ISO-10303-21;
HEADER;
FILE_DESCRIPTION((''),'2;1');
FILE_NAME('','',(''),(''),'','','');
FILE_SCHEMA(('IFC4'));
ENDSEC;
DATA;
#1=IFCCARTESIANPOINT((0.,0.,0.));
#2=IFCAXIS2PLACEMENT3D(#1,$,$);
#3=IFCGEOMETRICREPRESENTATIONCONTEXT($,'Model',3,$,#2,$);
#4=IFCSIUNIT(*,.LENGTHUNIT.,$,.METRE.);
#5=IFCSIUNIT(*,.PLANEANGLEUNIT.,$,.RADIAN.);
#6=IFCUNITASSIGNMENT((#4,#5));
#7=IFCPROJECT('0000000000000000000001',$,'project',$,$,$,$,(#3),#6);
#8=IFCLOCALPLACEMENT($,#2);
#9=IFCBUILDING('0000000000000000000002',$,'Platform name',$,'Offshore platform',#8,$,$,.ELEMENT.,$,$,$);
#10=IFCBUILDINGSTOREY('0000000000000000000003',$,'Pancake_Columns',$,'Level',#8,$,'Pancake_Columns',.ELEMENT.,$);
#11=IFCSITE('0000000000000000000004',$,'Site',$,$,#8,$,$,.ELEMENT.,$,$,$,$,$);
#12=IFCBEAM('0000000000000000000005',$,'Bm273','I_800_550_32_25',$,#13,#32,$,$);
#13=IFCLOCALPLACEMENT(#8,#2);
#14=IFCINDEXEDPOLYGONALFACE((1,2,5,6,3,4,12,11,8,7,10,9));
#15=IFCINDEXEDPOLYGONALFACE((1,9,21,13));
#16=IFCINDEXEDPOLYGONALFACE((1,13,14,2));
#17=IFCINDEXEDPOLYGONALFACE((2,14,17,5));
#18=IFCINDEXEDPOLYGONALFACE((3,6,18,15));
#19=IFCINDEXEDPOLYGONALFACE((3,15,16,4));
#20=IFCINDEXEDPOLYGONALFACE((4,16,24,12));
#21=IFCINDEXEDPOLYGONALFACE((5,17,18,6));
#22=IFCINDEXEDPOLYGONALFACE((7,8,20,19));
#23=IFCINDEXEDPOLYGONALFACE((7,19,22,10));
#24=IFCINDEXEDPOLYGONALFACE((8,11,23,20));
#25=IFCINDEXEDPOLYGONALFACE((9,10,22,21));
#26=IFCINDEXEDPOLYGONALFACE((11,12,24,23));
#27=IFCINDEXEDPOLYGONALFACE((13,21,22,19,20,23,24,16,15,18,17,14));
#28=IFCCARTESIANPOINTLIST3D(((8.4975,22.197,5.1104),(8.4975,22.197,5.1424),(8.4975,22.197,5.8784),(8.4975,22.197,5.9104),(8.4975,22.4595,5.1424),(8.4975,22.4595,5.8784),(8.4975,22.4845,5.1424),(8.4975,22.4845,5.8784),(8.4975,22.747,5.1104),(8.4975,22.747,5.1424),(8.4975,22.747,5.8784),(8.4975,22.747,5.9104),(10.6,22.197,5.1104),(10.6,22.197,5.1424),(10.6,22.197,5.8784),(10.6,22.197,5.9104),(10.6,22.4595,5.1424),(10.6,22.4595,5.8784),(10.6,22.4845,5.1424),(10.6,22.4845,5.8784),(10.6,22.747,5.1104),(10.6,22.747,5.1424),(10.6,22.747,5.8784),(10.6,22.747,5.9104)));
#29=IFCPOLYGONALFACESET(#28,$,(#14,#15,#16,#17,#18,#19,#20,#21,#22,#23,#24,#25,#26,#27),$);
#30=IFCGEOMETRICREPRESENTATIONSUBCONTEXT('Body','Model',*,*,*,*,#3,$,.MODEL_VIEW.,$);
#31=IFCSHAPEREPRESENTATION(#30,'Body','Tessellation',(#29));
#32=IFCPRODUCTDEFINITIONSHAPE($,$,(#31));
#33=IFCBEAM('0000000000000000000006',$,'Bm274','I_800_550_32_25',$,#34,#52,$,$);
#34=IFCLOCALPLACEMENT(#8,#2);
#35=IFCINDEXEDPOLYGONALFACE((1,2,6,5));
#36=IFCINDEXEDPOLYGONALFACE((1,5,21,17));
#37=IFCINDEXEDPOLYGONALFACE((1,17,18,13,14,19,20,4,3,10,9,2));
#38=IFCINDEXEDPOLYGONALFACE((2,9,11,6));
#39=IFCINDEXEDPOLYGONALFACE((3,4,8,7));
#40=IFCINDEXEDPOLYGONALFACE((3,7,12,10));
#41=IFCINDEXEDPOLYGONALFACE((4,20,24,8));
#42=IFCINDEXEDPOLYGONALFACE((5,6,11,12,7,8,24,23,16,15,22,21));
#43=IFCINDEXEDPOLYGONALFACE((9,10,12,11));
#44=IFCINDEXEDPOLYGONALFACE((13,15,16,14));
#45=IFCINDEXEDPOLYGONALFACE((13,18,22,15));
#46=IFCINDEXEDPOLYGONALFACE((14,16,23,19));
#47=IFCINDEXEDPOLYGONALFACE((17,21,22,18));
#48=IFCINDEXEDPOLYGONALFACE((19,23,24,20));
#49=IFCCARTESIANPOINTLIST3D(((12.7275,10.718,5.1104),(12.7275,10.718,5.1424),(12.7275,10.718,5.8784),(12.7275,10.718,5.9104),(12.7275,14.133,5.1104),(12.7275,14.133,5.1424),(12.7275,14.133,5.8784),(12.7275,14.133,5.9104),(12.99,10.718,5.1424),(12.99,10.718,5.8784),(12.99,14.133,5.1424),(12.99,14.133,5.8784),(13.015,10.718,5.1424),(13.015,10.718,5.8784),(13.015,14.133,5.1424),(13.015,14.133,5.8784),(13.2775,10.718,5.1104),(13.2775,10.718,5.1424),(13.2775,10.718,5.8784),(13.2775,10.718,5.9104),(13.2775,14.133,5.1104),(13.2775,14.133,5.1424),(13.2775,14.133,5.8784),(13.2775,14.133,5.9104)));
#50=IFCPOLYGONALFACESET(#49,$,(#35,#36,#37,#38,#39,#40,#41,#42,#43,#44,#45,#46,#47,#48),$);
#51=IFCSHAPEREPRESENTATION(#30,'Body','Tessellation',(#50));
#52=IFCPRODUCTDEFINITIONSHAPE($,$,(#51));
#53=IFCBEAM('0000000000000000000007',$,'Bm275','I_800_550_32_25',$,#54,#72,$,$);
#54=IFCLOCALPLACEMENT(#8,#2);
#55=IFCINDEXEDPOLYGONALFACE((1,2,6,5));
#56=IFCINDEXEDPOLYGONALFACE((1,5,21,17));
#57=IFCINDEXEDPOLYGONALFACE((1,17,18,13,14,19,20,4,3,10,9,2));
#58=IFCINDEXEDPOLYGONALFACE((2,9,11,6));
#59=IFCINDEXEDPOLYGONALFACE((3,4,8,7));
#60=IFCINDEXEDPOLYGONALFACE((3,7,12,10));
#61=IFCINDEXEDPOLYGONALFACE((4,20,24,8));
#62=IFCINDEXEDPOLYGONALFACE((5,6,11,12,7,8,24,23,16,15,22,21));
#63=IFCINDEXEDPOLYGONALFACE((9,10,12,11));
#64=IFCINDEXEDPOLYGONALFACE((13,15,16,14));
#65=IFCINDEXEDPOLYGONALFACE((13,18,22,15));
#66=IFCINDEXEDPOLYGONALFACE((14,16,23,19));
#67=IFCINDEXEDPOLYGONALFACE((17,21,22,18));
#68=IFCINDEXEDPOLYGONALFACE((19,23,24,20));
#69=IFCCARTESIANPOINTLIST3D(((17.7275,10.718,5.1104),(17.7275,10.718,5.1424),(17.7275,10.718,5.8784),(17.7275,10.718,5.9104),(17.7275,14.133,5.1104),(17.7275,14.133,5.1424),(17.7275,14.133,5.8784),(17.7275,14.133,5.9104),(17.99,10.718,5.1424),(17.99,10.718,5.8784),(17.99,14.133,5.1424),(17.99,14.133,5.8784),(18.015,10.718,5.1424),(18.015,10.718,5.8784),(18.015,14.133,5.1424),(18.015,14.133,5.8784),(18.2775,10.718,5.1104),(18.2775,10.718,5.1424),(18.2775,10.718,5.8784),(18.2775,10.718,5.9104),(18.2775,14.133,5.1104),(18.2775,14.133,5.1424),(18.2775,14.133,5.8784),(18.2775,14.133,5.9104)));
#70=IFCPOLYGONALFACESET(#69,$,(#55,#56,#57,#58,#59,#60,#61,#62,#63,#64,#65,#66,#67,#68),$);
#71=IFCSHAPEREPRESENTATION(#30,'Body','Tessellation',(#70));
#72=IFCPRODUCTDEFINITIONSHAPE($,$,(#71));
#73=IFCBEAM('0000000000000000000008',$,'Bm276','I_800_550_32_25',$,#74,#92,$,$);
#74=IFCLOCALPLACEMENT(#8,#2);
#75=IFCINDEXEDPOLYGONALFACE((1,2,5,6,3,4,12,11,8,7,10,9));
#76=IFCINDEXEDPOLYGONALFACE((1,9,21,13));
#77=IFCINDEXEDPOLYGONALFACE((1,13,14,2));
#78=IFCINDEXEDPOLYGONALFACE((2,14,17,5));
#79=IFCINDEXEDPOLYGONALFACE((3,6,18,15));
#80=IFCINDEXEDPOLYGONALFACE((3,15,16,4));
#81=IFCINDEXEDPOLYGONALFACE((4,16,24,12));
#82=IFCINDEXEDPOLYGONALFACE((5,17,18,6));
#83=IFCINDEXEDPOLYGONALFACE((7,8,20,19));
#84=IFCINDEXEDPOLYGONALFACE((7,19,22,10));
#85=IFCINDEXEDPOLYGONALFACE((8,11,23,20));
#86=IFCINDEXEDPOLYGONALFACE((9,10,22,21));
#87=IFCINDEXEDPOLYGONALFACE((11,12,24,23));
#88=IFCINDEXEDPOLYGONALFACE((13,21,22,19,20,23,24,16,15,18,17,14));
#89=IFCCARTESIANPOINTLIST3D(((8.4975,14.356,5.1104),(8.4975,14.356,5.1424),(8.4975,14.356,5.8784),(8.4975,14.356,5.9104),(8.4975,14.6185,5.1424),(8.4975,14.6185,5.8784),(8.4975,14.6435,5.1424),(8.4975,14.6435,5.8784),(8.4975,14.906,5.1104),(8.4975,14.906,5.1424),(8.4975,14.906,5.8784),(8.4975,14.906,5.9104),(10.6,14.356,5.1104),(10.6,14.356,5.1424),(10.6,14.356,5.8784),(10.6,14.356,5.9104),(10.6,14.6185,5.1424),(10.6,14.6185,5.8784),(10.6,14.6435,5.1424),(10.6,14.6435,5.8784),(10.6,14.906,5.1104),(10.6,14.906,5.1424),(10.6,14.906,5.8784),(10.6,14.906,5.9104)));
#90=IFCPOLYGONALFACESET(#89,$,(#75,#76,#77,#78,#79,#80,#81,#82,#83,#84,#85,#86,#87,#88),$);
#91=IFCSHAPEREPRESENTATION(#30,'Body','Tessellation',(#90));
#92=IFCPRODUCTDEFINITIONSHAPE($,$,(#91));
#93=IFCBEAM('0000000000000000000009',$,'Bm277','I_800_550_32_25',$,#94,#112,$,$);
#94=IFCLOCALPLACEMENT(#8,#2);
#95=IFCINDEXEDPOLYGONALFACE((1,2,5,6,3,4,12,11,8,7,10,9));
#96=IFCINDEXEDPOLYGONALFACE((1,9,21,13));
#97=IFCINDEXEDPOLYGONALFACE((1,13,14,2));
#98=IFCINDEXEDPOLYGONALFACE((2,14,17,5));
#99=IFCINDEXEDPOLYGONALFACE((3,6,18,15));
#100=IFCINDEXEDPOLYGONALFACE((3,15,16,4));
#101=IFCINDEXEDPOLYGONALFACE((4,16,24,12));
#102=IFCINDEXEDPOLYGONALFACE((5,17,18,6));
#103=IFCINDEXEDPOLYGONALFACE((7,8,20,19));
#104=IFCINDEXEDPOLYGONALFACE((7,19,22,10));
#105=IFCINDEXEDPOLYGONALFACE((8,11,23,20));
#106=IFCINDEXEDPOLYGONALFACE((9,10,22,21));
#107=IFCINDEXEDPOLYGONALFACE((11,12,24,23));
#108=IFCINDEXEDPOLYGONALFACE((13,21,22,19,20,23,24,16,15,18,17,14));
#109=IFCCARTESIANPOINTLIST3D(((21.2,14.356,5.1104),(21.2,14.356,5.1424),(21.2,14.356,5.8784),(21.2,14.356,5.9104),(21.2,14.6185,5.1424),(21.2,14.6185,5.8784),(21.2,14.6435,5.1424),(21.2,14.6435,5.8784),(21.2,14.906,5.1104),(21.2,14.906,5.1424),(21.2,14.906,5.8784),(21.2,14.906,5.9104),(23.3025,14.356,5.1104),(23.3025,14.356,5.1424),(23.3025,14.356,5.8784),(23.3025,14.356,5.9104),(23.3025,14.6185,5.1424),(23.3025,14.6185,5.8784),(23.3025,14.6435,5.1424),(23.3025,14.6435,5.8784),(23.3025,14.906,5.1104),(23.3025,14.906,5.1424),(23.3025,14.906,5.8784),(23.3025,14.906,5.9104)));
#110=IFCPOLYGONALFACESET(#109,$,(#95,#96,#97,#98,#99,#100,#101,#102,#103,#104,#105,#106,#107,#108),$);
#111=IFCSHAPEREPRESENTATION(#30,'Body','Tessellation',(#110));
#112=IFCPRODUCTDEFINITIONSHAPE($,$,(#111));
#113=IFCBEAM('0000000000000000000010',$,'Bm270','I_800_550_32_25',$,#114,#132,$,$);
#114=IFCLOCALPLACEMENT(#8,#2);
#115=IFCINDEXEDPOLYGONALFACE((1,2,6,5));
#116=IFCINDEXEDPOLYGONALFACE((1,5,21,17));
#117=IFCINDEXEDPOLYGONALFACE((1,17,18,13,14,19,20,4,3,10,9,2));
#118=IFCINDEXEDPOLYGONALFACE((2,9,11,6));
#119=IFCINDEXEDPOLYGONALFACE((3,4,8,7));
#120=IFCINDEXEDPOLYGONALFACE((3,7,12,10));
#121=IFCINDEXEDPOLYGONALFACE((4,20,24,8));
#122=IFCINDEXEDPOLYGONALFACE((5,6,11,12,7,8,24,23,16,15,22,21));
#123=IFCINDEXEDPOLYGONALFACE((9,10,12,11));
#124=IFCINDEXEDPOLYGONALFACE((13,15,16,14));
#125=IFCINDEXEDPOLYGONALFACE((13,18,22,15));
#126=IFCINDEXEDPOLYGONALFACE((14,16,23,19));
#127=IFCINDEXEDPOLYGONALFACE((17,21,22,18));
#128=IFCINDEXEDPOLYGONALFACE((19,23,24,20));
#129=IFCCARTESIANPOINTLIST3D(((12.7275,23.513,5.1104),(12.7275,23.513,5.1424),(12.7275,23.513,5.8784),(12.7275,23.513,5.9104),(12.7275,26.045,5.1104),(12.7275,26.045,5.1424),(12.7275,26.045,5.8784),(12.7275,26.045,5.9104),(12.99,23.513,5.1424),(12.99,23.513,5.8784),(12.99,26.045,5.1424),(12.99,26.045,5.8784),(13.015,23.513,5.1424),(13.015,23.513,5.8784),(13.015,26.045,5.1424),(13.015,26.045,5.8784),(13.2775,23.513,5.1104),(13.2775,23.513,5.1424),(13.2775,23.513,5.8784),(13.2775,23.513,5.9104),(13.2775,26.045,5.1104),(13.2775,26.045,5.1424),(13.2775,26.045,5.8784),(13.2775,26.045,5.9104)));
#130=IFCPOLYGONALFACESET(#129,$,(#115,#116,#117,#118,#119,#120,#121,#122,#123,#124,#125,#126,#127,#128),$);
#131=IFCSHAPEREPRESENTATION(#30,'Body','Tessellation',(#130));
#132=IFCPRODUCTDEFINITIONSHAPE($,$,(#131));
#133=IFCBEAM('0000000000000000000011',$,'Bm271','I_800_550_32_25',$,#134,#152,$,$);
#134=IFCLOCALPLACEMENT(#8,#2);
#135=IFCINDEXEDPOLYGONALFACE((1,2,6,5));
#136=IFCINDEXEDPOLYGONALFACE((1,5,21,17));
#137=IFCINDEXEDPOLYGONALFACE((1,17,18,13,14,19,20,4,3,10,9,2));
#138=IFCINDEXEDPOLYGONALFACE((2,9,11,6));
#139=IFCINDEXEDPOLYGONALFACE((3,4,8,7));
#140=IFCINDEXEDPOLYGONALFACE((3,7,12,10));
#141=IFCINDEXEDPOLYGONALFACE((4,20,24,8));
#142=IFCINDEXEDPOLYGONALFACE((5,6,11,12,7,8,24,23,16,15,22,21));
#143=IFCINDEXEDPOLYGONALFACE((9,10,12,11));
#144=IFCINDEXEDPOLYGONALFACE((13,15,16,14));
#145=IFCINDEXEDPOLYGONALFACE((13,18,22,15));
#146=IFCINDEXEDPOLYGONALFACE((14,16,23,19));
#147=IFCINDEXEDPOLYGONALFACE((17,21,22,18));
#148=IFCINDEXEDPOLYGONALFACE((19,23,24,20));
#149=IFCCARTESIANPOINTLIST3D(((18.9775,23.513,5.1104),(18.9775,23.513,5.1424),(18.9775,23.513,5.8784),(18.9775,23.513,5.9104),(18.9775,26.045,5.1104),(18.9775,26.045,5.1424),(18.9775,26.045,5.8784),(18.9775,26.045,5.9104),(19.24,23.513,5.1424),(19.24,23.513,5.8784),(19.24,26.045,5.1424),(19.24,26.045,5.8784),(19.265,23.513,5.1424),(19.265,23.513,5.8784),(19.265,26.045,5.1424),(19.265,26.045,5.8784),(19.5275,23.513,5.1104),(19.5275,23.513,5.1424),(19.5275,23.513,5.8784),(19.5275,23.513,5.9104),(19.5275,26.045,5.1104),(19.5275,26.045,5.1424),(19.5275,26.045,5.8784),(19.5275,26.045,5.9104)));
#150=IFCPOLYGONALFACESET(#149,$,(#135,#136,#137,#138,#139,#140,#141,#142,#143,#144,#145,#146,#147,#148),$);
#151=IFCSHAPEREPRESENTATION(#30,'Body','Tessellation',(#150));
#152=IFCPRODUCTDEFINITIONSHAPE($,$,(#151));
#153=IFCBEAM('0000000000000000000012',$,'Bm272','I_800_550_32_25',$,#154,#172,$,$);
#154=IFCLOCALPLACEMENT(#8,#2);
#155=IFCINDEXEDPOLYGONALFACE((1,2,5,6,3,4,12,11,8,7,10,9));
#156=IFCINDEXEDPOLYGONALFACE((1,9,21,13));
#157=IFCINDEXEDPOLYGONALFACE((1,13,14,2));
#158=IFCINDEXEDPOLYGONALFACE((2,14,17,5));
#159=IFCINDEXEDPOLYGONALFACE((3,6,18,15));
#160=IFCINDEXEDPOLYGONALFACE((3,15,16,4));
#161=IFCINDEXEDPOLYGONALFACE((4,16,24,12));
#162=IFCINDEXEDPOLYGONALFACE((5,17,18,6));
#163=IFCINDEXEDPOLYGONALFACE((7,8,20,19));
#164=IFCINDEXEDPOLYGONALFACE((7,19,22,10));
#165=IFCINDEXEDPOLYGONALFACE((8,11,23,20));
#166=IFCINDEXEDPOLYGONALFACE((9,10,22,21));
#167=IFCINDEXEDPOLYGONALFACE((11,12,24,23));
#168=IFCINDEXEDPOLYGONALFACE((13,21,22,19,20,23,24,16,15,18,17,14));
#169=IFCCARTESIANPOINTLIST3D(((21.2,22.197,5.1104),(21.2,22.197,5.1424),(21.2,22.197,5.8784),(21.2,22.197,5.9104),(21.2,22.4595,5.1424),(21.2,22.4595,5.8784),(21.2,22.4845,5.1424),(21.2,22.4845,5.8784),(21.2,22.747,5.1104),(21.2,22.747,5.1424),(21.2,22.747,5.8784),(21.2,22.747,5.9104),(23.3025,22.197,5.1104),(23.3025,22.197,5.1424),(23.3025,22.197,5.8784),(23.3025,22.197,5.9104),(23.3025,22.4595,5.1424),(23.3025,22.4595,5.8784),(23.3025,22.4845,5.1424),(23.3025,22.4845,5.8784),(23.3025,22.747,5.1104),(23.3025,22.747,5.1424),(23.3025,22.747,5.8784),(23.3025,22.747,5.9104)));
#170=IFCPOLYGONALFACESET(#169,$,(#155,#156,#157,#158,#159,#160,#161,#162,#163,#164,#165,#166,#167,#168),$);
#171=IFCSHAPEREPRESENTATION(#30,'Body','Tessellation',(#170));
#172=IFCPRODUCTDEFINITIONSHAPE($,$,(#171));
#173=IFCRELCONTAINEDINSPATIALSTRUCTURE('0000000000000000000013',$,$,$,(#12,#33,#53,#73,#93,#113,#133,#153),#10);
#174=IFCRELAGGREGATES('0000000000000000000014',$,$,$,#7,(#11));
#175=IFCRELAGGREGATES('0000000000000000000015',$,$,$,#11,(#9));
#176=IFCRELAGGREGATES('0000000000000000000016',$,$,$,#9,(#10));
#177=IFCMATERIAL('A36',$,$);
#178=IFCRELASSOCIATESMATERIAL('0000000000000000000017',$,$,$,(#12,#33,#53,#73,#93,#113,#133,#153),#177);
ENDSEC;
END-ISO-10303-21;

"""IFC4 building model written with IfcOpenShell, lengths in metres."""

from ifc_helpers import new_model, si_unit, frame, origin, origin_2d, place, context, subcontext, project, spatial, i_section, extrude, source, transform, mapped, material, element, save


model = new_model("IFC4")

# Units and contexts
model_context = context("Model", 3, world=origin())
body_context = subcontext(model_context, "Body", "Model", "MODEL_VIEW")
ifc_project = project(units=[si_unit("LENGTHUNIT", "METRE"), si_unit("PLANEANGLEUNIT", "RADIAN")], contexts=[model_context])

# Site, building, storey
placement_1 = place(None, origin())
site = spatial("IfcSite", under=ifc_project, at=placement_1, Name="Site", CompositionType="ELEMENT")
building = spatial("IfcBuilding", under=site, at=placement_1, Name="Platform name", ObjectType="Offshore platform", CompositionType="ELEMENT")
storey = spatial("IfcBuildingStorey", under=building, at=placement_1, Name="Pancake_Columns", ObjectType="Level", LongName="Pancake_Columns", CompositionType="ELEMENT")

# Beams
ifc_material = material(Name="A36")
shared_shape_1 = source(origin(), body_context, "Body", "SweptSolid", [
    extrude(i_section(OverallWidth=0.55, OverallDepth=0.8, WebThickness=0.025, FlangeThickness=0.032, FilletRadius=0.0, at=origin_2d()), frame((0.0, 0.0, 0.0), z_axis=(1.0, 0.0, 0.0), x_axis=(0.0, 1.0, 0.0)), (0.0, 0.0, 1.0), 2.1025),
])
placement_2 = place(None, origin())
placement_3 = place(placement_2, origin())
placement_4 = place(placement_3, origin())
beam_1_placement = place(placement_4, frame((8.4975, 22.472, 5.5104)))
element("IfcBeam", 1, at=beam_1_placement, inside=storey, material=ifc_material, Name="Bm273", Description="I_800_550_32_25", context=body_context, shape_type="MappedRepresentation", body=[
    mapped(shared_shape_1, transform((0.0, 0.0, 0.0), scale=1.0)),
])
shared_shape_2 = source(origin(), body_context, "Body", "SweptSolid", [
    extrude(i_section(OverallWidth=0.55, OverallDepth=0.8, WebThickness=0.025, FlangeThickness=0.032, FilletRadius=0.0, at=origin_2d()), frame((0.0, 0.0, 0.0), z_axis=(0.0, -1.0, 0.0), x_axis=(1.0, 0.0, 0.0)), (0.0, 0.0, 1.0), 3.415),
])
placement_5 = place(None, origin())
placement_6 = place(placement_5, origin())
placement_7 = place(placement_6, origin())
beam_2_placement = place(placement_7, frame((13.0025, 14.133, 5.5104)))
element("IfcBeam", 2, at=beam_2_placement, inside=storey, material=ifc_material, Name="Bm274", Description="I_800_550_32_25", context=body_context, shape_type="MappedRepresentation", body=[
    mapped(shared_shape_2, transform((0.0, 0.0, 0.0), scale=1.0)),
])
shared_shape_3 = source(origin(), body_context, "Body", "SweptSolid", [
    extrude(i_section(OverallWidth=0.55, OverallDepth=0.8, WebThickness=0.025, FlangeThickness=0.032, FilletRadius=0.0, at=origin_2d()), frame((0.0, 0.0, 0.0), z_axis=(0.0, -1.0, 0.0), x_axis=(1.0, 0.0, 0.0)), (0.0, 0.0, 1.0), 3.415),
])
placement_8 = place(None, origin())
placement_9 = place(placement_8, origin())
placement_10 = place(placement_9, origin())
beam_3_placement = place(placement_10, frame((18.0025, 14.133, 5.5104)))
element("IfcBeam", 3, at=beam_3_placement, inside=storey, material=ifc_material, Name="Bm275", Description="I_800_550_32_25", context=body_context, shape_type="MappedRepresentation", body=[
    mapped(shared_shape_3, transform((0.0, 0.0, 0.0), scale=1.0)),
])
shared_shape_4 = source(origin(), body_context, "Body", "SweptSolid", [
    extrude(i_section(OverallWidth=0.55, OverallDepth=0.8, WebThickness=0.025, FlangeThickness=0.032, FilletRadius=0.0, at=origin_2d()), frame((0.0, 0.0, 0.0), z_axis=(1.0, 0.0, 0.0), x_axis=(0.0, 1.0, 0.0)), (0.0, 0.0, 1.0), 2.1025),
])
placement_11 = place(None, origin())
placement_12 = place(placement_11, origin())
placement_13 = place(placement_12, origin())
beam_4_placement = place(placement_13, frame((8.4975, 14.631, 5.5104)))
element("IfcBeam", 4, at=beam_4_placement, inside=storey, material=ifc_material, Name="Bm276", Description="I_800_550_32_25", context=body_context, shape_type="MappedRepresentation", body=[
    mapped(shared_shape_4, transform((0.0, 0.0, 0.0), scale=1.0)),
])
shared_shape_5 = source(origin(), body_context, "Body", "SweptSolid", [
    extrude(i_section(OverallWidth=0.55, OverallDepth=0.8, WebThickness=0.025, FlangeThickness=0.032, FilletRadius=0.0, at=origin_2d()), frame((0.0, 0.0, 0.0), z_axis=(1.0, 0.0, 0.0), x_axis=(0.0, 1.0, 0.0)), (0.0, 0.0, 1.0), 2.1025),
])
placement_14 = place(None, origin())
placement_15 = place(placement_14, origin())
placement_16 = place(placement_15, origin())
beam_5_placement = place(placement_16, frame((21.2, 14.631, 5.5104)))
element("IfcBeam", 5, at=beam_5_placement, inside=storey, material=ifc_material, Name="Bm277", Description="I_800_550_32_25", context=body_context, shape_type="MappedRepresentation", body=[
    mapped(shared_shape_5, transform((0.0, 0.0, 0.0), scale=1.0)),
])
shared_shape_6 = source(origin(), body_context, "Body", "SweptSolid", [
    extrude(i_section(OverallWidth=0.55, OverallDepth=0.8, WebThickness=0.025, FlangeThickness=0.032, FilletRadius=0.0, at=origin_2d()), frame((0.0, 0.0, 0.0), z_axis=(0.0, -1.0, 0.0), x_axis=(1.0, 0.0, 0.0)), (0.0, 0.0, 1.0), 2.532),
])
placement_17 = place(None, origin())
placement_18 = place(placement_17, origin())
placement_19 = place(placement_18, origin())
beam_6_placement = place(placement_19, frame((13.0025, 26.045, 5.5104)))
element("IfcBeam", 6, at=beam_6_placement, inside=storey, material=ifc_material, Name="Bm270", Description="I_800_550_32_25", context=body_context, shape_type="MappedRepresentation", body=[
    mapped(shared_shape_6, transform((0.0, 0.0, 0.0), scale=1.0)),
])
shared_shape_7 = source(origin(), body_context, "Body", "SweptSolid", [
    extrude(i_section(OverallWidth=0.55, OverallDepth=0.8, WebThickness=0.025, FlangeThickness=0.032, FilletRadius=0.0, at=origin_2d()), frame((0.0, 0.0, 0.0), z_axis=(0.0, -1.0, 0.0), x_axis=(1.0, 0.0, 0.0)), (0.0, 0.0, 1.0), 2.532),
])
placement_20 = place(None, origin())
placement_21 = place(placement_20, origin())
placement_22 = place(placement_21, origin())
beam_7_placement = place(placement_22, frame((19.2525, 26.045, 5.5104)))
element("IfcBeam", 7, at=beam_7_placement, inside=storey, material=ifc_material, Name="Bm271", Description="I_800_550_32_25", context=body_context, shape_type="MappedRepresentation", body=[
    mapped(shared_shape_7, transform((0.0, 0.0, 0.0), scale=1.0)),
])
shared_shape_8 = source(origin(), body_context, "Body", "SweptSolid", [
    extrude(i_section(OverallWidth=0.55, OverallDepth=0.8, WebThickness=0.025, FlangeThickness=0.032, FilletRadius=0.0, at=origin_2d()), frame((0.0, 0.0, 0.0), z_axis=(1.0, 0.0, 0.0), x_axis=(0.0, 1.0, 0.0)), (0.0, 0.0, 1.0), 2.1025),
])
placement_23 = place(None, origin())
placement_24 = place(placement_23, origin())
placement_25 = place(placement_24, origin())
beam_8_placement = place(placement_25, frame((21.2, 22.472, 5.5104)))
element("IfcBeam", 8, at=beam_8_placement, inside=storey, material=ifc_material, Name="Bm272", Description="I_800_550_32_25", context=body_context, shape_type="MappedRepresentation", body=[
    mapped(shared_shape_8, transform((0.0, 0.0, 0.0), scale=1.0)),
])

save(model, "model.ifc")
